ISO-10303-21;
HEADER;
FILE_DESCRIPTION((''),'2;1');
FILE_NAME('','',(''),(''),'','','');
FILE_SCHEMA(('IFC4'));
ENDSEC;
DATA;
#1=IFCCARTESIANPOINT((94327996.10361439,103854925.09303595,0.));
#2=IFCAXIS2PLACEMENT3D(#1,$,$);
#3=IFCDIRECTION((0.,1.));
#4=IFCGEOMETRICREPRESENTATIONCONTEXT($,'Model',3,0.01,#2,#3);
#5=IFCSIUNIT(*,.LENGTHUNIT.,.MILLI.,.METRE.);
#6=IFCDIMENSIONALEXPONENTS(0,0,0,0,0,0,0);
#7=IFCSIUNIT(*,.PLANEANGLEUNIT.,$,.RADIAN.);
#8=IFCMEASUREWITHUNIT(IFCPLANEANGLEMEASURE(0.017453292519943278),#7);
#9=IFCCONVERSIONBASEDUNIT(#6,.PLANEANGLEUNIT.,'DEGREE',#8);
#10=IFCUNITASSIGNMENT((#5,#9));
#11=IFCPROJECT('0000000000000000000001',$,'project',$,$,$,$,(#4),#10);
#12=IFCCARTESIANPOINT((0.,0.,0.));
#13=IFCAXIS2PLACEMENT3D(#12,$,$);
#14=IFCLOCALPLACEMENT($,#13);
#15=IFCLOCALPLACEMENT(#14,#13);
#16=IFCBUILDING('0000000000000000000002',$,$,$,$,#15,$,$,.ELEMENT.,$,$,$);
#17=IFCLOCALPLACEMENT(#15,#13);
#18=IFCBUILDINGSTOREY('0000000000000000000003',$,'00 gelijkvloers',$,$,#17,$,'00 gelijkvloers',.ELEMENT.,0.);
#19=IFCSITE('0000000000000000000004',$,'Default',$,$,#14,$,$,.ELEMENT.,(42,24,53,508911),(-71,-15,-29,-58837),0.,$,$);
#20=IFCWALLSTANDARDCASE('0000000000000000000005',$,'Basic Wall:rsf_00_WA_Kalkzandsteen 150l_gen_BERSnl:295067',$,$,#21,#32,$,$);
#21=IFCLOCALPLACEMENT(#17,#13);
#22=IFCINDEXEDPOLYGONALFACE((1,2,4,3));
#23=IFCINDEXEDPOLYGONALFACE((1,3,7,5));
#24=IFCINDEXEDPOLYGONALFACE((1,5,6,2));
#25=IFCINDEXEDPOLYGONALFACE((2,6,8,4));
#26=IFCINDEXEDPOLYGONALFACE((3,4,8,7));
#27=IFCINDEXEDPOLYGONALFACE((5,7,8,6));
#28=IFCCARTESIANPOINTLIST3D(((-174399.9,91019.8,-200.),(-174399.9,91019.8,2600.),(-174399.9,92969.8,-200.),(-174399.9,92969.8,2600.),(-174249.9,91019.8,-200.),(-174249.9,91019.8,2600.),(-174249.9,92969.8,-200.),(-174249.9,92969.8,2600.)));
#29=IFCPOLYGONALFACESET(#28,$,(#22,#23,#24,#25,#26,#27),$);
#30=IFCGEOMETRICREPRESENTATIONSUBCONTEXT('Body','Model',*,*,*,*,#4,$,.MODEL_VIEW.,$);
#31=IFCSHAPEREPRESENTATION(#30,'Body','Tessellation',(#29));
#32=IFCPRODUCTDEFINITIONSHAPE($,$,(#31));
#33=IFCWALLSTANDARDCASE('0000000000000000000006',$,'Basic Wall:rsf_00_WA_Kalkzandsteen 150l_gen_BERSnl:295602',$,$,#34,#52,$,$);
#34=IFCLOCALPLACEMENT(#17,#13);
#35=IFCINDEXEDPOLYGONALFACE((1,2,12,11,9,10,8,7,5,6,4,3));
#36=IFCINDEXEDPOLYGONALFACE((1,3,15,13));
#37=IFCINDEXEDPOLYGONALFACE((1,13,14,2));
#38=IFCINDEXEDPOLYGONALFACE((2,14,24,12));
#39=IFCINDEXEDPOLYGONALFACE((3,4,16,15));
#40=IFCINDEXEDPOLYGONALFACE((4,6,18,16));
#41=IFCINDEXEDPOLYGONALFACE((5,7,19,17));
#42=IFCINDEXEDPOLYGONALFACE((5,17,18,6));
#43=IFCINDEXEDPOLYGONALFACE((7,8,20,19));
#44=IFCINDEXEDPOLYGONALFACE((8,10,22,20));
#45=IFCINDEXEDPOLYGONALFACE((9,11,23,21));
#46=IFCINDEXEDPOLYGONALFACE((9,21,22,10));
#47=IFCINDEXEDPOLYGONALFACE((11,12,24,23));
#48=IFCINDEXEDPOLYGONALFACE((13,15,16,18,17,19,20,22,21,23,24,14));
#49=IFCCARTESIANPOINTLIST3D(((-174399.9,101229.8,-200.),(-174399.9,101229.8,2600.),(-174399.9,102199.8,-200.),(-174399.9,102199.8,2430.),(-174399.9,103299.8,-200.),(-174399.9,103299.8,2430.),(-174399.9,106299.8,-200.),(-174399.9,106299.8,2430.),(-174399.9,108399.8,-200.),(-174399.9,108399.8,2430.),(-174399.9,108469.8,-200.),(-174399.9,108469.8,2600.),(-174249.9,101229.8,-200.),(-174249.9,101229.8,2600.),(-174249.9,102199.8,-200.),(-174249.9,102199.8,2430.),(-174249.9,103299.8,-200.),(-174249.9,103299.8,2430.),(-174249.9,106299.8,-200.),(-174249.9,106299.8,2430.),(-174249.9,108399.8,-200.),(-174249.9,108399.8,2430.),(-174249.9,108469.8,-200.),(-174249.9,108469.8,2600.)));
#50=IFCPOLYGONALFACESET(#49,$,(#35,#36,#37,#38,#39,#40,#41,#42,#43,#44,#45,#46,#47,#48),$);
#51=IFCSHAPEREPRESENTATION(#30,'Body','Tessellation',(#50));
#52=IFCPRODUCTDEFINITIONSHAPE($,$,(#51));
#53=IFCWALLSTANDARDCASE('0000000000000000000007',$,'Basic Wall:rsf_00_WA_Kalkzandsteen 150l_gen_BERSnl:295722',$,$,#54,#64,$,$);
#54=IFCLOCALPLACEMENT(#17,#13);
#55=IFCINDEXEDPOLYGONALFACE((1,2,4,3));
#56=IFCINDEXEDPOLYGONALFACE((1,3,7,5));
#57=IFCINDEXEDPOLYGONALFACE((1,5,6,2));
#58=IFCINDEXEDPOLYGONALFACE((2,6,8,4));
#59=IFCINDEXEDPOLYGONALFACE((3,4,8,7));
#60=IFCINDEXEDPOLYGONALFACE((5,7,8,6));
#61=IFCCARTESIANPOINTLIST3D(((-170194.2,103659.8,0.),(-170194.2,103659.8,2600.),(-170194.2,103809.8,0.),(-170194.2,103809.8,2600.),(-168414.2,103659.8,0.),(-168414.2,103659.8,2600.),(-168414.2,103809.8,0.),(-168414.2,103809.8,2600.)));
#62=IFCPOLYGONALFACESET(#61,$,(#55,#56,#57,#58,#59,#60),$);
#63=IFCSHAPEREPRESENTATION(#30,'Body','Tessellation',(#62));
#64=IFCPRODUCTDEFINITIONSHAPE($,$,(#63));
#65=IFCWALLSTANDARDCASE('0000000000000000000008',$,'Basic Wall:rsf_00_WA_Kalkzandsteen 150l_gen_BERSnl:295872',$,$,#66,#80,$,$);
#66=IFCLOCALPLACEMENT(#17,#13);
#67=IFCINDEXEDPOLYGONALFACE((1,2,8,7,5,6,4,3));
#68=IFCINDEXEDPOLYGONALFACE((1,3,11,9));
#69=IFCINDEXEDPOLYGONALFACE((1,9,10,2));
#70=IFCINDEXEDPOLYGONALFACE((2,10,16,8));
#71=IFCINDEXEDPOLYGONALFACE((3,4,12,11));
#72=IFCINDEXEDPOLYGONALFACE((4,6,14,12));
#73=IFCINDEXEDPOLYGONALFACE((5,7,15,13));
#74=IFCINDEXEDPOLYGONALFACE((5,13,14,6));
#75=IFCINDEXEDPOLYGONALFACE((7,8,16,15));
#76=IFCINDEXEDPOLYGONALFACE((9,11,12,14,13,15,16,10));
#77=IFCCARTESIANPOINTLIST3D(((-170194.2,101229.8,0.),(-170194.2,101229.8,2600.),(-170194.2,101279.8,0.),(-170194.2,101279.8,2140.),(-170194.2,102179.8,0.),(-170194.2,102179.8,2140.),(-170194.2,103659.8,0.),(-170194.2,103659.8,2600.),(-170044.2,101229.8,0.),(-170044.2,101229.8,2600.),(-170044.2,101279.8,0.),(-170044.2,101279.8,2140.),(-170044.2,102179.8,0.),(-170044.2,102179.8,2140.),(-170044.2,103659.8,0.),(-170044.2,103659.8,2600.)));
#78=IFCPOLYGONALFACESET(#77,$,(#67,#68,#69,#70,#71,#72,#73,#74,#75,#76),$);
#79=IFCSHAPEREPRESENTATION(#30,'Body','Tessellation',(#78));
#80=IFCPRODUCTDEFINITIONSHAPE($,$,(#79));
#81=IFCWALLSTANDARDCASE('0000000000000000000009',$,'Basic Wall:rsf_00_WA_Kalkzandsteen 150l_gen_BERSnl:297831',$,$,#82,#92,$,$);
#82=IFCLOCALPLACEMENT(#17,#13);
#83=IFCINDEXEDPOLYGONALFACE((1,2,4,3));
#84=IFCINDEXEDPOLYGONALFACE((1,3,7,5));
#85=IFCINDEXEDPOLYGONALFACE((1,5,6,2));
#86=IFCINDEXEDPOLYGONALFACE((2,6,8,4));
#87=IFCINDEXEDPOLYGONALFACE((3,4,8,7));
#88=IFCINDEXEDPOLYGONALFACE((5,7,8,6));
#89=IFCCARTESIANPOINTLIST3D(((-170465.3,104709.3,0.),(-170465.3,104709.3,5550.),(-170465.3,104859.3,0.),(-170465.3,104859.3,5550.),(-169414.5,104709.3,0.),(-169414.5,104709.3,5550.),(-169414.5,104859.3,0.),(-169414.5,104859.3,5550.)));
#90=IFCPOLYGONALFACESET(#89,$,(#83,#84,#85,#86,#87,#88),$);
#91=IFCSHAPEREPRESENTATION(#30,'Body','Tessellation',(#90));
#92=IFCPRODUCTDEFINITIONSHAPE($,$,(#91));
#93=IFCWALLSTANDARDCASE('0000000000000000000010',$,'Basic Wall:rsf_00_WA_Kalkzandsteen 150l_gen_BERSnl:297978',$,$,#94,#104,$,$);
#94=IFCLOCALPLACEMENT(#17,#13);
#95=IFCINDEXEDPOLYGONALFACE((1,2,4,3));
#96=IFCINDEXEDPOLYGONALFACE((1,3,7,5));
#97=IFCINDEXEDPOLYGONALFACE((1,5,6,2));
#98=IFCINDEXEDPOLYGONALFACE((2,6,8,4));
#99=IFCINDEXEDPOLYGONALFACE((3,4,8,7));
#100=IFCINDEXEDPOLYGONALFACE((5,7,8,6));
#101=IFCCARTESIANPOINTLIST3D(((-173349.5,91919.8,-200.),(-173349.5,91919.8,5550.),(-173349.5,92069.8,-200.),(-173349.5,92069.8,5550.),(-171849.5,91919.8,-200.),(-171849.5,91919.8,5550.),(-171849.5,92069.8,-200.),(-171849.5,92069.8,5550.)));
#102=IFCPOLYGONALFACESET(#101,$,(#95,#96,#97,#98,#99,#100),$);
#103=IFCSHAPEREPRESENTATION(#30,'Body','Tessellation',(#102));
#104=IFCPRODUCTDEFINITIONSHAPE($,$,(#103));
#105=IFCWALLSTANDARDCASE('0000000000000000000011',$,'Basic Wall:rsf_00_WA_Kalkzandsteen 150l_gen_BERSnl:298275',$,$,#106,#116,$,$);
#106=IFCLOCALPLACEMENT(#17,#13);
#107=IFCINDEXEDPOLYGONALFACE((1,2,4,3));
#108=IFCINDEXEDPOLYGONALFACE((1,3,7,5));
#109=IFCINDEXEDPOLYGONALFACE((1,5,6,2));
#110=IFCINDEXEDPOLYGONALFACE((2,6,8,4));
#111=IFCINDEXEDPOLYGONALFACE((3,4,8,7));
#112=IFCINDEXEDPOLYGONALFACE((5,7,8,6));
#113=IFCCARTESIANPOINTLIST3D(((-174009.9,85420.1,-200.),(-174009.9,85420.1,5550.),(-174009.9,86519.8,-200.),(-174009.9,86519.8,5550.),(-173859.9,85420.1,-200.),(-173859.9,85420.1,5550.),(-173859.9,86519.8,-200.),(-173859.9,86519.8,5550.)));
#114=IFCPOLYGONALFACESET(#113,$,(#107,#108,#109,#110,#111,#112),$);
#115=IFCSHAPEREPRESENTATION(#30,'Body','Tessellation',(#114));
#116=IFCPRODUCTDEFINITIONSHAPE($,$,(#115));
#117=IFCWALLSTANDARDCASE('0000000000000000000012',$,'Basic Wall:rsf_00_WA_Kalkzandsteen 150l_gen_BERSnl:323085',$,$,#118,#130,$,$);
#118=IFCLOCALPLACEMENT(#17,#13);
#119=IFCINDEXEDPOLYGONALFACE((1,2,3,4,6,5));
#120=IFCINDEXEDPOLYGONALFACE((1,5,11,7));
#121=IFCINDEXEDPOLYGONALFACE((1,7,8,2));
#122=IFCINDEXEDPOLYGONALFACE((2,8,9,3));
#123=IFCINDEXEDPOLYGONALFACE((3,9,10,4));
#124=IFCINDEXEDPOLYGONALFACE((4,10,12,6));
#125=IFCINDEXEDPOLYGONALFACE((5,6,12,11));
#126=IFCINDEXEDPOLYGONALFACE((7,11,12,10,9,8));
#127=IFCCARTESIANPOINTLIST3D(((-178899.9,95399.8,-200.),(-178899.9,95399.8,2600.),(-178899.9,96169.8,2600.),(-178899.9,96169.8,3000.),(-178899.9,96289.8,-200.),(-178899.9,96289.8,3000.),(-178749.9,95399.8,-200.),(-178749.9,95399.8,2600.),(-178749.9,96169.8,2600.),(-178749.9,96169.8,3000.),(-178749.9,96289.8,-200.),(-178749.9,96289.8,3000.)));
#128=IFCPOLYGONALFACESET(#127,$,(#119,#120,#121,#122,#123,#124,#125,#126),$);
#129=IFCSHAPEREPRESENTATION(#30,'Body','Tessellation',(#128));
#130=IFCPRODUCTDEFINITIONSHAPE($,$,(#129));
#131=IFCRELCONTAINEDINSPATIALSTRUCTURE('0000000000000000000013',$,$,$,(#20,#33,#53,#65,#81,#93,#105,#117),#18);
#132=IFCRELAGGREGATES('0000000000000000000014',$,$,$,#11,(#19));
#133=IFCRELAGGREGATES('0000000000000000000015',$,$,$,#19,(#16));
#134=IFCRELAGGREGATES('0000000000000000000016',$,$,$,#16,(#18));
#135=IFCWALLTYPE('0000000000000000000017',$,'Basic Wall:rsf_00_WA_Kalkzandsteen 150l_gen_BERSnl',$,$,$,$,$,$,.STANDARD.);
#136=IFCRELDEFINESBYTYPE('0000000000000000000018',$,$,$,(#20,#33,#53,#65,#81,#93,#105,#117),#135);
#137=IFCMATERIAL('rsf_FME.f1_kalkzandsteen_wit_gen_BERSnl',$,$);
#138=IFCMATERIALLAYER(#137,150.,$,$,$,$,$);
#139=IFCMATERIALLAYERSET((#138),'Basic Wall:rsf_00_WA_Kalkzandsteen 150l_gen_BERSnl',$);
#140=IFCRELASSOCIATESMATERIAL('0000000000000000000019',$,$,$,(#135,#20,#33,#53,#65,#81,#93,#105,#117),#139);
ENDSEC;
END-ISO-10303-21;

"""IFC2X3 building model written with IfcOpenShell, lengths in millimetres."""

from ifc_helpers import new_model, entity, si_unit, converted_unit, direction, frame, frame_2d, origin, origin_2d_with_axis, place, context, subcontext, project, spatial, polyline, rectangle, extrude, clip, bounded_halfspace, material, layer, layer_set, layer_usage, type_object, element, save


model = new_model("IFC2X3")

# Units and contexts
model_context = context("Model", 3, precision=0.01, world=frame((94327996.10361439, 103854925.09303595, 0.0)), true_north=direction((0.0, 1.0)))
body_context = subcontext(model_context, "Body", "Model", "MODEL_VIEW")
ifc_project = project(units=[si_unit("LENGTHUNIT", "METRE", prefix="MILLI"), converted_unit("PLANEANGLEUNIT", "DEGREE", entity("IfcPlaneAngleMeasure", 0.017453292519943278), si_unit("PLANEANGLEUNIT", "RADIAN"), dimensions=[0, 0, 0, 0, 0, 0, 0])], contexts=[model_context])

# Site, building, storey
site_placement = place(None, origin())
site = spatial("IfcSite", under=ifc_project, at=site_placement, Name="Default", CompositionType="ELEMENT", RefLatitude=(42, 24, 53, 508911), RefLongitude=(-71, -15, -29, -58837), RefElevation=0.0)
building_placement = place(site_placement, origin())
building = spatial("IfcBuilding", under=site, at=building_placement, CompositionType="ELEMENT")
storey_placement = place(building_placement, origin())
storey = spatial("IfcBuildingStorey", under=building, at=storey_placement, Name="00 gelijkvloers", LongName="00 gelijkvloers", CompositionType="ELEMENT", Elevation=0.0)

# Shared definitions
ifc_material = material(Name="rsf_FME.f1_kalkzandsteen_wit_gen_BERSnl")
ifc_layer = layer(ifc_material, 150.0)
ifc_layer_set = layer_set([ifc_layer], Name="Basic Wall:rsf_00_WA_Kalkzandsteen 150l_gen_BERSnl")
wall_type = type_object("IfcWallType", Name="Basic Wall:rsf_00_WA_Kalkzandsteen 150l_gen_BERSnl", PredefinedType="STANDARD", material=ifc_layer_set)

# Wall
ifc_layer_usage_1 = layer_usage(ifc_layer_set, "AXIS2", "POSITIVE", -75.0)
wall_1_placement = place(storey_placement, frame((-174324.9, 92969.8, -200.0), z_axis=(0.0, 0.0, 1.0), x_axis=(0.0, -1.0, 0.0)))
element("IfcWallStandardCase", 1, at=wall_1_placement, inside=storey, type_object=wall_type, material=ifc_layer_usage_1, Name="Basic Wall:rsf_00_WA_Kalkzandsteen 150l_gen_BERSnl:295067", context=body_context, shape_type="Clipping", body=[
    clip(clip(extrude(rectangle(XDim=1950.0, YDim=150.0, at=frame_2d((975.0, 0.0), x_axis=(-1.0, 0.0))), origin(), (0.0, 0.0, 1.0), 2800.0), bounded_halfspace(frame((1950.0, -75.0, 0.0), z_axis=(0.0, 0.0, 1.0), x_axis=(0.0, 1.0, 0.0)), True, frame((1950.0, -75.0, 0.0)), polyline([(0.0, 0.0), (0.0, 150.0), (-1950.0, 150.0), (-1950.0, 0.0), (0.0, 0.0)]))), bounded_halfspace(frame((0.0, -75.0, 2800.0), z_axis=(0.0, 0.0, -1.0), x_axis=(-1.0, 0.0, 0.0)), True, frame((0.0, -75.0, 2800.0)), polyline([(0.0, 0.0), (1950.0, 0.0), (1950.0, 150.0), (0.0, 150.0), (0.0, 0.0)]))),
])

# Wall, openings
ifc_layer_usage_2 = layer_usage(ifc_layer_set, "AXIS2", "NEGATIVE", 75.0)
wall_2_placement = place(storey_placement, frame((-174324.9, 108469.8, -200.0), z_axis=(0.0, 0.0, 1.0), x_axis=(0.0, -1.0, 0.0)))
wall_2 = element("IfcWallStandardCase", 2, at=wall_2_placement, inside=storey, type_object=wall_type, material=ifc_layer_usage_2, Name="Basic Wall:rsf_00_WA_Kalkzandsteen 150l_gen_BERSnl:295602", context=body_context, shape_type="Clipping", body=[
    clip(extrude(rectangle(XDim=7240.0, YDim=150.0, at=frame_2d((3620.0, 0.0), x_axis=(1.0, 0.0))), origin(), (0.0, 0.0, 1.0), 2800.0), bounded_halfspace(frame((0.0, -75.0, 2800.0), z_axis=(0.0, 0.0, -1.0), x_axis=(-1.0, 0.0, 0.0)), True, frame((0.0, -75.0, 2800.0)), polyline([(0.0, 0.0), (7240.0, 0.0), (7240.0, 150.0), (0.0, 150.0), (0.0, 0.0)]))),
])
opening_1_placement = place(wall_2_placement, frame((108469.8, 174324.9, 200.0), z_axis=(0.0, 0.0, 1.0), x_axis=(0.0, 1.0, 0.0)))
element("IfcOpeningElement", 3, at=opening_1_placement, cuts=wall_2, ObjectType="Opening", context=body_context, shape_type="SweptSolid", body=[
    extrude(rectangle(XDim=2630.0, YDim=1100.0, at=frame_2d((0.0, 0.0), x_axis=(0.0, 1.0))), frame((-175923.9, 102749.8, 1115.0), z_axis=(1.0, 0.0, 0.0), x_axis=(0.0, 1.0, 0.0)), (0.0, 0.0, 1.0), 3048.0),
])
opening_2_placement = place(wall_2_placement, frame((108469.8, 174324.9, 200.0), z_axis=(0.0, 0.0, 1.0), x_axis=(0.0, 1.0, 0.0)))
element("IfcOpeningElement", 4, at=opening_2_placement, cuts=wall_2, ObjectType="Opening", context=body_context, shape_type="SweptSolid", body=[
    extrude(rectangle(XDim=2630.0, YDim=2100.0, at=origin_2d_with_axis()), frame((-175773.9, 107349.8, 1115.0), z_axis=(1.0, 0.0, 0.0), x_axis=(0.0, 0.0, 1.0)), (0.0, 0.0, 1.0), 3048.0),
])

# Wall
ifc_layer_usage_3 = layer_usage(ifc_layer_set, "AXIS2", "NEGATIVE", 75.0)
wall_3_placement = place(storey_placement, frame((-170194.2, 103734.8, 0.0)))
element("IfcWallStandardCase", 5, at=wall_3_placement, inside=storey, type_object=wall_type, material=ifc_layer_usage_3, Name="Basic Wall:rsf_00_WA_Kalkzandsteen 150l_gen_BERSnl:295722", context=body_context, shape_type="Clipping", body=[
    clip(extrude(rectangle(XDim=1780.0, YDim=150.0, at=frame_2d((890.0, 0.0), x_axis=(-1.0, 0.0))), origin(), (0.0, 0.0, 1.0), 2600.0), bounded_halfspace(frame((0.0, -75.0, 2600.0), z_axis=(0.0, 0.0, -1.0), x_axis=(0.0, 1.0, 0.0)), True, frame((0.0, -75.0, 2600.0)), polyline([(0.0, 0.0), (150.0, 0.0), (1780.0, 0.0), (1780.0, 150.0), (0.0, 150.0), (0.0, 0.0)]))),
])

# Wall, opening
ifc_layer_usage_4 = layer_usage(ifc_layer_set, "AXIS2", "POSITIVE", -75.0)
wall_4_placement = place(storey_placement, frame((-170119.2, 103659.8, 0.0), z_axis=(0.0, 0.0, 1.0), x_axis=(0.0, -1.0, 0.0)))
wall_4 = element("IfcWallStandardCase", 6, at=wall_4_placement, inside=storey, type_object=wall_type, material=ifc_layer_usage_4, Name="Basic Wall:rsf_00_WA_Kalkzandsteen 150l_gen_BERSnl:295872", context=body_context, shape_type="Clipping", body=[
    clip(extrude(rectangle(XDim=2430.0, YDim=150.0, at=frame_2d((1215.0, 0.0), x_axis=(1.0, 0.0))), origin(), (0.0, 0.0, 1.0), 2600.0), bounded_halfspace(frame((0.0, -75.0, 2600.0), z_axis=(0.0, 0.0, -1.0), x_axis=(-1.0, 0.0, 0.0)), True, frame((0.0, -75.0, 2600.0)), polyline([(0.0, 0.0), (2430.0, 0.0), (2430.0, 150.0), (0.0, 150.0), (0.0, 0.0)]))),
])
opening_3_placement = place(wall_4_placement, frame((103659.8, 170119.2, 0.0), z_axis=(0.0, 0.0, 1.0), x_axis=(0.0, 1.0, 0.0)))
element("IfcOpeningElement", 7, at=opening_3_placement, cuts=wall_4, ObjectType="Opening", context=body_context, shape_type="SweptSolid", body=[
    extrude(rectangle(XDim=2340.0, YDim=900.0, at=frame_2d((0.0, 0.0), x_axis=(0.0, 1.0))), frame((-171718.2, 101729.8, 970.0), z_axis=(1.0, 0.0, 0.0), x_axis=(0.0, 1.0, 0.0)), (0.0, 0.0, 1.0), 3048.0),
])

# Walls
ifc_layer_usage_5 = layer_usage(ifc_layer_set, "AXIS2", "NEGATIVE", 75.0)
wall_5_placement = place(storey_placement, frame((-170465.3, 104784.3, 0.0)))
element("IfcWallStandardCase", 8, at=wall_5_placement, inside=storey, type_object=wall_type, material=ifc_layer_usage_5, Name="Basic Wall:rsf_00_WA_Kalkzandsteen 150l_gen_BERSnl:297831", context=body_context, shape_type="Clipping", body=[
    clip(extrude(rectangle(XDim=1050.8, YDim=150.0, at=frame_2d((525.4, 0.0), x_axis=(-1.0, 0.0))), origin(), (0.0, 0.0, 1.0), 5550.0), bounded_halfspace(frame((0.0, -75.0, 5550.0), z_axis=(0.0, 0.0, -1.0), x_axis=(0.0, 1.0, 0.0)), True, frame((0.0, -75.0, 5550.0)), polyline([(0.0, 0.0), (1050.8, 0.0), (1050.8, 150.0), (0.0, 150.0), (0.0, 0.0)]))),
])
ifc_layer_usage_6 = layer_usage(ifc_layer_set, "AXIS2", "NEGATIVE", 75.0)
wall_6_placement = place(storey_placement, frame((-171849.5, 91994.8, -200.0), z_axis=(0.0, 0.0, 1.0), x_axis=(-1.0, 0.0, 0.0)))
element("IfcWallStandardCase", 9, at=wall_6_placement, inside=storey, type_object=wall_type, material=ifc_layer_usage_6, Name="Basic Wall:rsf_00_WA_Kalkzandsteen 150l_gen_BERSnl:297978", context=body_context, shape_type="Clipping", body=[
    clip(clip(extrude(rectangle(XDim=1500.0, YDim=150.0, at=frame_2d((750.0, 0.0), x_axis=(-1.0, 0.0))), origin(), (0.0, 0.0, 1.0), 5750.0), bounded_halfspace(frame((1500.0, -75.0, 0.0), z_axis=(0.0, 0.0, 1.0), x_axis=(-1.0, 0.0, 0.0)), True, frame((1500.0, -75.0, 0.0)), polyline([(0.0, 0.0), (0.0, 150.0), (-1500.0, 150.0), (-1500.0, 0.0), (0.0, 0.0)]))), bounded_halfspace(frame((0.0, -75.0, 5750.0), z_axis=(0.0, 0.0, -1.0), x_axis=(0.0, -1.0, 0.0)), True, frame((0.0, -75.0, 5750.0)), polyline([(0.0, 0.0), (1500.0, 0.0), (1500.0, 150.0), (0.0, 150.0), (0.0, 0.0)]))),
])
ifc_layer_usage_7 = layer_usage(ifc_layer_set, "AXIS2", "POSITIVE", -75.0)
wall_7_placement = place(storey_placement, frame((-173934.9, 86519.8, -200.0), z_axis=(0.0, 0.0, 1.0), x_axis=(0.0, -1.0, 0.0)))
element("IfcWallStandardCase", 10, at=wall_7_placement, inside=storey, type_object=wall_type, material=ifc_layer_usage_7, Name="Basic Wall:rsf_00_WA_Kalkzandsteen 150l_gen_BERSnl:298275", context=body_context, shape_type="Clipping", body=[
    clip(clip(extrude(rectangle(XDim=1099.6, YDim=150.0, at=frame_2d((549.8, 0.0), x_axis=(-1.0, 0.0))), origin(), (0.0, 0.0, 1.0), 5750.0), bounded_halfspace(frame((1099.6, -75.0, 0.0), z_axis=(0.0, 0.0, 1.0), x_axis=(0.0, 1.0, 0.0)), True, frame((1099.6, -75.0, 0.0)), polyline([(0.0, 0.0), (0.0, 150.0), (-1099.6, 150.0), (-1099.6, 0.0), (0.0, 0.0)]))), bounded_halfspace(frame((0.0, -75.0, 5750.0), z_axis=(0.0, 0.0, -1.0), x_axis=(-1.0, 0.0, 0.0)), True, frame((0.0, -75.0, 5750.0)), polyline([(0.0, 0.0), (1099.6, 0.0), (1099.6, 150.0), (0.0, 150.0), (0.0, 0.0)]))),
])
ifc_layer_usage_8 = layer_usage(ifc_layer_set, "AXIS2", "POSITIVE", -75.0)
wall_8_placement = place(storey_placement, frame((-178824.9, 95399.8, -200.0), z_axis=(0.0, 0.0, 1.0), x_axis=(0.0, 1.0, 0.0)))
element("IfcWallStandardCase", 11, at=wall_8_placement, inside=storey, type_object=wall_type, material=ifc_layer_usage_8, Name="Basic Wall:rsf_00_WA_Kalkzandsteen 150l_gen_BERSnl:323085", context=body_context, shape_type="Clipping", body=[
    clip(extrude(rectangle(XDim=890.0, YDim=150.0, at=frame_2d((445.0, 0.0), x_axis=(-1.0, 0.0))), origin(), (0.0, 0.0, 1.0), 3200.0), bounded_halfspace(frame((0.0, -75.0, 2800.0), z_axis=(0.0, 0.0, -1.0), x_axis=(1.0, 0.0, 0.0)), True, frame((0.0, -75.0, 2800.0)), polyline([(0.0, 0.0), (770.0, 0.0), (770.0, 150.0), (0.0, 150.0), (0.0, 0.0)]))),
])

save(model, "model.ifc")
